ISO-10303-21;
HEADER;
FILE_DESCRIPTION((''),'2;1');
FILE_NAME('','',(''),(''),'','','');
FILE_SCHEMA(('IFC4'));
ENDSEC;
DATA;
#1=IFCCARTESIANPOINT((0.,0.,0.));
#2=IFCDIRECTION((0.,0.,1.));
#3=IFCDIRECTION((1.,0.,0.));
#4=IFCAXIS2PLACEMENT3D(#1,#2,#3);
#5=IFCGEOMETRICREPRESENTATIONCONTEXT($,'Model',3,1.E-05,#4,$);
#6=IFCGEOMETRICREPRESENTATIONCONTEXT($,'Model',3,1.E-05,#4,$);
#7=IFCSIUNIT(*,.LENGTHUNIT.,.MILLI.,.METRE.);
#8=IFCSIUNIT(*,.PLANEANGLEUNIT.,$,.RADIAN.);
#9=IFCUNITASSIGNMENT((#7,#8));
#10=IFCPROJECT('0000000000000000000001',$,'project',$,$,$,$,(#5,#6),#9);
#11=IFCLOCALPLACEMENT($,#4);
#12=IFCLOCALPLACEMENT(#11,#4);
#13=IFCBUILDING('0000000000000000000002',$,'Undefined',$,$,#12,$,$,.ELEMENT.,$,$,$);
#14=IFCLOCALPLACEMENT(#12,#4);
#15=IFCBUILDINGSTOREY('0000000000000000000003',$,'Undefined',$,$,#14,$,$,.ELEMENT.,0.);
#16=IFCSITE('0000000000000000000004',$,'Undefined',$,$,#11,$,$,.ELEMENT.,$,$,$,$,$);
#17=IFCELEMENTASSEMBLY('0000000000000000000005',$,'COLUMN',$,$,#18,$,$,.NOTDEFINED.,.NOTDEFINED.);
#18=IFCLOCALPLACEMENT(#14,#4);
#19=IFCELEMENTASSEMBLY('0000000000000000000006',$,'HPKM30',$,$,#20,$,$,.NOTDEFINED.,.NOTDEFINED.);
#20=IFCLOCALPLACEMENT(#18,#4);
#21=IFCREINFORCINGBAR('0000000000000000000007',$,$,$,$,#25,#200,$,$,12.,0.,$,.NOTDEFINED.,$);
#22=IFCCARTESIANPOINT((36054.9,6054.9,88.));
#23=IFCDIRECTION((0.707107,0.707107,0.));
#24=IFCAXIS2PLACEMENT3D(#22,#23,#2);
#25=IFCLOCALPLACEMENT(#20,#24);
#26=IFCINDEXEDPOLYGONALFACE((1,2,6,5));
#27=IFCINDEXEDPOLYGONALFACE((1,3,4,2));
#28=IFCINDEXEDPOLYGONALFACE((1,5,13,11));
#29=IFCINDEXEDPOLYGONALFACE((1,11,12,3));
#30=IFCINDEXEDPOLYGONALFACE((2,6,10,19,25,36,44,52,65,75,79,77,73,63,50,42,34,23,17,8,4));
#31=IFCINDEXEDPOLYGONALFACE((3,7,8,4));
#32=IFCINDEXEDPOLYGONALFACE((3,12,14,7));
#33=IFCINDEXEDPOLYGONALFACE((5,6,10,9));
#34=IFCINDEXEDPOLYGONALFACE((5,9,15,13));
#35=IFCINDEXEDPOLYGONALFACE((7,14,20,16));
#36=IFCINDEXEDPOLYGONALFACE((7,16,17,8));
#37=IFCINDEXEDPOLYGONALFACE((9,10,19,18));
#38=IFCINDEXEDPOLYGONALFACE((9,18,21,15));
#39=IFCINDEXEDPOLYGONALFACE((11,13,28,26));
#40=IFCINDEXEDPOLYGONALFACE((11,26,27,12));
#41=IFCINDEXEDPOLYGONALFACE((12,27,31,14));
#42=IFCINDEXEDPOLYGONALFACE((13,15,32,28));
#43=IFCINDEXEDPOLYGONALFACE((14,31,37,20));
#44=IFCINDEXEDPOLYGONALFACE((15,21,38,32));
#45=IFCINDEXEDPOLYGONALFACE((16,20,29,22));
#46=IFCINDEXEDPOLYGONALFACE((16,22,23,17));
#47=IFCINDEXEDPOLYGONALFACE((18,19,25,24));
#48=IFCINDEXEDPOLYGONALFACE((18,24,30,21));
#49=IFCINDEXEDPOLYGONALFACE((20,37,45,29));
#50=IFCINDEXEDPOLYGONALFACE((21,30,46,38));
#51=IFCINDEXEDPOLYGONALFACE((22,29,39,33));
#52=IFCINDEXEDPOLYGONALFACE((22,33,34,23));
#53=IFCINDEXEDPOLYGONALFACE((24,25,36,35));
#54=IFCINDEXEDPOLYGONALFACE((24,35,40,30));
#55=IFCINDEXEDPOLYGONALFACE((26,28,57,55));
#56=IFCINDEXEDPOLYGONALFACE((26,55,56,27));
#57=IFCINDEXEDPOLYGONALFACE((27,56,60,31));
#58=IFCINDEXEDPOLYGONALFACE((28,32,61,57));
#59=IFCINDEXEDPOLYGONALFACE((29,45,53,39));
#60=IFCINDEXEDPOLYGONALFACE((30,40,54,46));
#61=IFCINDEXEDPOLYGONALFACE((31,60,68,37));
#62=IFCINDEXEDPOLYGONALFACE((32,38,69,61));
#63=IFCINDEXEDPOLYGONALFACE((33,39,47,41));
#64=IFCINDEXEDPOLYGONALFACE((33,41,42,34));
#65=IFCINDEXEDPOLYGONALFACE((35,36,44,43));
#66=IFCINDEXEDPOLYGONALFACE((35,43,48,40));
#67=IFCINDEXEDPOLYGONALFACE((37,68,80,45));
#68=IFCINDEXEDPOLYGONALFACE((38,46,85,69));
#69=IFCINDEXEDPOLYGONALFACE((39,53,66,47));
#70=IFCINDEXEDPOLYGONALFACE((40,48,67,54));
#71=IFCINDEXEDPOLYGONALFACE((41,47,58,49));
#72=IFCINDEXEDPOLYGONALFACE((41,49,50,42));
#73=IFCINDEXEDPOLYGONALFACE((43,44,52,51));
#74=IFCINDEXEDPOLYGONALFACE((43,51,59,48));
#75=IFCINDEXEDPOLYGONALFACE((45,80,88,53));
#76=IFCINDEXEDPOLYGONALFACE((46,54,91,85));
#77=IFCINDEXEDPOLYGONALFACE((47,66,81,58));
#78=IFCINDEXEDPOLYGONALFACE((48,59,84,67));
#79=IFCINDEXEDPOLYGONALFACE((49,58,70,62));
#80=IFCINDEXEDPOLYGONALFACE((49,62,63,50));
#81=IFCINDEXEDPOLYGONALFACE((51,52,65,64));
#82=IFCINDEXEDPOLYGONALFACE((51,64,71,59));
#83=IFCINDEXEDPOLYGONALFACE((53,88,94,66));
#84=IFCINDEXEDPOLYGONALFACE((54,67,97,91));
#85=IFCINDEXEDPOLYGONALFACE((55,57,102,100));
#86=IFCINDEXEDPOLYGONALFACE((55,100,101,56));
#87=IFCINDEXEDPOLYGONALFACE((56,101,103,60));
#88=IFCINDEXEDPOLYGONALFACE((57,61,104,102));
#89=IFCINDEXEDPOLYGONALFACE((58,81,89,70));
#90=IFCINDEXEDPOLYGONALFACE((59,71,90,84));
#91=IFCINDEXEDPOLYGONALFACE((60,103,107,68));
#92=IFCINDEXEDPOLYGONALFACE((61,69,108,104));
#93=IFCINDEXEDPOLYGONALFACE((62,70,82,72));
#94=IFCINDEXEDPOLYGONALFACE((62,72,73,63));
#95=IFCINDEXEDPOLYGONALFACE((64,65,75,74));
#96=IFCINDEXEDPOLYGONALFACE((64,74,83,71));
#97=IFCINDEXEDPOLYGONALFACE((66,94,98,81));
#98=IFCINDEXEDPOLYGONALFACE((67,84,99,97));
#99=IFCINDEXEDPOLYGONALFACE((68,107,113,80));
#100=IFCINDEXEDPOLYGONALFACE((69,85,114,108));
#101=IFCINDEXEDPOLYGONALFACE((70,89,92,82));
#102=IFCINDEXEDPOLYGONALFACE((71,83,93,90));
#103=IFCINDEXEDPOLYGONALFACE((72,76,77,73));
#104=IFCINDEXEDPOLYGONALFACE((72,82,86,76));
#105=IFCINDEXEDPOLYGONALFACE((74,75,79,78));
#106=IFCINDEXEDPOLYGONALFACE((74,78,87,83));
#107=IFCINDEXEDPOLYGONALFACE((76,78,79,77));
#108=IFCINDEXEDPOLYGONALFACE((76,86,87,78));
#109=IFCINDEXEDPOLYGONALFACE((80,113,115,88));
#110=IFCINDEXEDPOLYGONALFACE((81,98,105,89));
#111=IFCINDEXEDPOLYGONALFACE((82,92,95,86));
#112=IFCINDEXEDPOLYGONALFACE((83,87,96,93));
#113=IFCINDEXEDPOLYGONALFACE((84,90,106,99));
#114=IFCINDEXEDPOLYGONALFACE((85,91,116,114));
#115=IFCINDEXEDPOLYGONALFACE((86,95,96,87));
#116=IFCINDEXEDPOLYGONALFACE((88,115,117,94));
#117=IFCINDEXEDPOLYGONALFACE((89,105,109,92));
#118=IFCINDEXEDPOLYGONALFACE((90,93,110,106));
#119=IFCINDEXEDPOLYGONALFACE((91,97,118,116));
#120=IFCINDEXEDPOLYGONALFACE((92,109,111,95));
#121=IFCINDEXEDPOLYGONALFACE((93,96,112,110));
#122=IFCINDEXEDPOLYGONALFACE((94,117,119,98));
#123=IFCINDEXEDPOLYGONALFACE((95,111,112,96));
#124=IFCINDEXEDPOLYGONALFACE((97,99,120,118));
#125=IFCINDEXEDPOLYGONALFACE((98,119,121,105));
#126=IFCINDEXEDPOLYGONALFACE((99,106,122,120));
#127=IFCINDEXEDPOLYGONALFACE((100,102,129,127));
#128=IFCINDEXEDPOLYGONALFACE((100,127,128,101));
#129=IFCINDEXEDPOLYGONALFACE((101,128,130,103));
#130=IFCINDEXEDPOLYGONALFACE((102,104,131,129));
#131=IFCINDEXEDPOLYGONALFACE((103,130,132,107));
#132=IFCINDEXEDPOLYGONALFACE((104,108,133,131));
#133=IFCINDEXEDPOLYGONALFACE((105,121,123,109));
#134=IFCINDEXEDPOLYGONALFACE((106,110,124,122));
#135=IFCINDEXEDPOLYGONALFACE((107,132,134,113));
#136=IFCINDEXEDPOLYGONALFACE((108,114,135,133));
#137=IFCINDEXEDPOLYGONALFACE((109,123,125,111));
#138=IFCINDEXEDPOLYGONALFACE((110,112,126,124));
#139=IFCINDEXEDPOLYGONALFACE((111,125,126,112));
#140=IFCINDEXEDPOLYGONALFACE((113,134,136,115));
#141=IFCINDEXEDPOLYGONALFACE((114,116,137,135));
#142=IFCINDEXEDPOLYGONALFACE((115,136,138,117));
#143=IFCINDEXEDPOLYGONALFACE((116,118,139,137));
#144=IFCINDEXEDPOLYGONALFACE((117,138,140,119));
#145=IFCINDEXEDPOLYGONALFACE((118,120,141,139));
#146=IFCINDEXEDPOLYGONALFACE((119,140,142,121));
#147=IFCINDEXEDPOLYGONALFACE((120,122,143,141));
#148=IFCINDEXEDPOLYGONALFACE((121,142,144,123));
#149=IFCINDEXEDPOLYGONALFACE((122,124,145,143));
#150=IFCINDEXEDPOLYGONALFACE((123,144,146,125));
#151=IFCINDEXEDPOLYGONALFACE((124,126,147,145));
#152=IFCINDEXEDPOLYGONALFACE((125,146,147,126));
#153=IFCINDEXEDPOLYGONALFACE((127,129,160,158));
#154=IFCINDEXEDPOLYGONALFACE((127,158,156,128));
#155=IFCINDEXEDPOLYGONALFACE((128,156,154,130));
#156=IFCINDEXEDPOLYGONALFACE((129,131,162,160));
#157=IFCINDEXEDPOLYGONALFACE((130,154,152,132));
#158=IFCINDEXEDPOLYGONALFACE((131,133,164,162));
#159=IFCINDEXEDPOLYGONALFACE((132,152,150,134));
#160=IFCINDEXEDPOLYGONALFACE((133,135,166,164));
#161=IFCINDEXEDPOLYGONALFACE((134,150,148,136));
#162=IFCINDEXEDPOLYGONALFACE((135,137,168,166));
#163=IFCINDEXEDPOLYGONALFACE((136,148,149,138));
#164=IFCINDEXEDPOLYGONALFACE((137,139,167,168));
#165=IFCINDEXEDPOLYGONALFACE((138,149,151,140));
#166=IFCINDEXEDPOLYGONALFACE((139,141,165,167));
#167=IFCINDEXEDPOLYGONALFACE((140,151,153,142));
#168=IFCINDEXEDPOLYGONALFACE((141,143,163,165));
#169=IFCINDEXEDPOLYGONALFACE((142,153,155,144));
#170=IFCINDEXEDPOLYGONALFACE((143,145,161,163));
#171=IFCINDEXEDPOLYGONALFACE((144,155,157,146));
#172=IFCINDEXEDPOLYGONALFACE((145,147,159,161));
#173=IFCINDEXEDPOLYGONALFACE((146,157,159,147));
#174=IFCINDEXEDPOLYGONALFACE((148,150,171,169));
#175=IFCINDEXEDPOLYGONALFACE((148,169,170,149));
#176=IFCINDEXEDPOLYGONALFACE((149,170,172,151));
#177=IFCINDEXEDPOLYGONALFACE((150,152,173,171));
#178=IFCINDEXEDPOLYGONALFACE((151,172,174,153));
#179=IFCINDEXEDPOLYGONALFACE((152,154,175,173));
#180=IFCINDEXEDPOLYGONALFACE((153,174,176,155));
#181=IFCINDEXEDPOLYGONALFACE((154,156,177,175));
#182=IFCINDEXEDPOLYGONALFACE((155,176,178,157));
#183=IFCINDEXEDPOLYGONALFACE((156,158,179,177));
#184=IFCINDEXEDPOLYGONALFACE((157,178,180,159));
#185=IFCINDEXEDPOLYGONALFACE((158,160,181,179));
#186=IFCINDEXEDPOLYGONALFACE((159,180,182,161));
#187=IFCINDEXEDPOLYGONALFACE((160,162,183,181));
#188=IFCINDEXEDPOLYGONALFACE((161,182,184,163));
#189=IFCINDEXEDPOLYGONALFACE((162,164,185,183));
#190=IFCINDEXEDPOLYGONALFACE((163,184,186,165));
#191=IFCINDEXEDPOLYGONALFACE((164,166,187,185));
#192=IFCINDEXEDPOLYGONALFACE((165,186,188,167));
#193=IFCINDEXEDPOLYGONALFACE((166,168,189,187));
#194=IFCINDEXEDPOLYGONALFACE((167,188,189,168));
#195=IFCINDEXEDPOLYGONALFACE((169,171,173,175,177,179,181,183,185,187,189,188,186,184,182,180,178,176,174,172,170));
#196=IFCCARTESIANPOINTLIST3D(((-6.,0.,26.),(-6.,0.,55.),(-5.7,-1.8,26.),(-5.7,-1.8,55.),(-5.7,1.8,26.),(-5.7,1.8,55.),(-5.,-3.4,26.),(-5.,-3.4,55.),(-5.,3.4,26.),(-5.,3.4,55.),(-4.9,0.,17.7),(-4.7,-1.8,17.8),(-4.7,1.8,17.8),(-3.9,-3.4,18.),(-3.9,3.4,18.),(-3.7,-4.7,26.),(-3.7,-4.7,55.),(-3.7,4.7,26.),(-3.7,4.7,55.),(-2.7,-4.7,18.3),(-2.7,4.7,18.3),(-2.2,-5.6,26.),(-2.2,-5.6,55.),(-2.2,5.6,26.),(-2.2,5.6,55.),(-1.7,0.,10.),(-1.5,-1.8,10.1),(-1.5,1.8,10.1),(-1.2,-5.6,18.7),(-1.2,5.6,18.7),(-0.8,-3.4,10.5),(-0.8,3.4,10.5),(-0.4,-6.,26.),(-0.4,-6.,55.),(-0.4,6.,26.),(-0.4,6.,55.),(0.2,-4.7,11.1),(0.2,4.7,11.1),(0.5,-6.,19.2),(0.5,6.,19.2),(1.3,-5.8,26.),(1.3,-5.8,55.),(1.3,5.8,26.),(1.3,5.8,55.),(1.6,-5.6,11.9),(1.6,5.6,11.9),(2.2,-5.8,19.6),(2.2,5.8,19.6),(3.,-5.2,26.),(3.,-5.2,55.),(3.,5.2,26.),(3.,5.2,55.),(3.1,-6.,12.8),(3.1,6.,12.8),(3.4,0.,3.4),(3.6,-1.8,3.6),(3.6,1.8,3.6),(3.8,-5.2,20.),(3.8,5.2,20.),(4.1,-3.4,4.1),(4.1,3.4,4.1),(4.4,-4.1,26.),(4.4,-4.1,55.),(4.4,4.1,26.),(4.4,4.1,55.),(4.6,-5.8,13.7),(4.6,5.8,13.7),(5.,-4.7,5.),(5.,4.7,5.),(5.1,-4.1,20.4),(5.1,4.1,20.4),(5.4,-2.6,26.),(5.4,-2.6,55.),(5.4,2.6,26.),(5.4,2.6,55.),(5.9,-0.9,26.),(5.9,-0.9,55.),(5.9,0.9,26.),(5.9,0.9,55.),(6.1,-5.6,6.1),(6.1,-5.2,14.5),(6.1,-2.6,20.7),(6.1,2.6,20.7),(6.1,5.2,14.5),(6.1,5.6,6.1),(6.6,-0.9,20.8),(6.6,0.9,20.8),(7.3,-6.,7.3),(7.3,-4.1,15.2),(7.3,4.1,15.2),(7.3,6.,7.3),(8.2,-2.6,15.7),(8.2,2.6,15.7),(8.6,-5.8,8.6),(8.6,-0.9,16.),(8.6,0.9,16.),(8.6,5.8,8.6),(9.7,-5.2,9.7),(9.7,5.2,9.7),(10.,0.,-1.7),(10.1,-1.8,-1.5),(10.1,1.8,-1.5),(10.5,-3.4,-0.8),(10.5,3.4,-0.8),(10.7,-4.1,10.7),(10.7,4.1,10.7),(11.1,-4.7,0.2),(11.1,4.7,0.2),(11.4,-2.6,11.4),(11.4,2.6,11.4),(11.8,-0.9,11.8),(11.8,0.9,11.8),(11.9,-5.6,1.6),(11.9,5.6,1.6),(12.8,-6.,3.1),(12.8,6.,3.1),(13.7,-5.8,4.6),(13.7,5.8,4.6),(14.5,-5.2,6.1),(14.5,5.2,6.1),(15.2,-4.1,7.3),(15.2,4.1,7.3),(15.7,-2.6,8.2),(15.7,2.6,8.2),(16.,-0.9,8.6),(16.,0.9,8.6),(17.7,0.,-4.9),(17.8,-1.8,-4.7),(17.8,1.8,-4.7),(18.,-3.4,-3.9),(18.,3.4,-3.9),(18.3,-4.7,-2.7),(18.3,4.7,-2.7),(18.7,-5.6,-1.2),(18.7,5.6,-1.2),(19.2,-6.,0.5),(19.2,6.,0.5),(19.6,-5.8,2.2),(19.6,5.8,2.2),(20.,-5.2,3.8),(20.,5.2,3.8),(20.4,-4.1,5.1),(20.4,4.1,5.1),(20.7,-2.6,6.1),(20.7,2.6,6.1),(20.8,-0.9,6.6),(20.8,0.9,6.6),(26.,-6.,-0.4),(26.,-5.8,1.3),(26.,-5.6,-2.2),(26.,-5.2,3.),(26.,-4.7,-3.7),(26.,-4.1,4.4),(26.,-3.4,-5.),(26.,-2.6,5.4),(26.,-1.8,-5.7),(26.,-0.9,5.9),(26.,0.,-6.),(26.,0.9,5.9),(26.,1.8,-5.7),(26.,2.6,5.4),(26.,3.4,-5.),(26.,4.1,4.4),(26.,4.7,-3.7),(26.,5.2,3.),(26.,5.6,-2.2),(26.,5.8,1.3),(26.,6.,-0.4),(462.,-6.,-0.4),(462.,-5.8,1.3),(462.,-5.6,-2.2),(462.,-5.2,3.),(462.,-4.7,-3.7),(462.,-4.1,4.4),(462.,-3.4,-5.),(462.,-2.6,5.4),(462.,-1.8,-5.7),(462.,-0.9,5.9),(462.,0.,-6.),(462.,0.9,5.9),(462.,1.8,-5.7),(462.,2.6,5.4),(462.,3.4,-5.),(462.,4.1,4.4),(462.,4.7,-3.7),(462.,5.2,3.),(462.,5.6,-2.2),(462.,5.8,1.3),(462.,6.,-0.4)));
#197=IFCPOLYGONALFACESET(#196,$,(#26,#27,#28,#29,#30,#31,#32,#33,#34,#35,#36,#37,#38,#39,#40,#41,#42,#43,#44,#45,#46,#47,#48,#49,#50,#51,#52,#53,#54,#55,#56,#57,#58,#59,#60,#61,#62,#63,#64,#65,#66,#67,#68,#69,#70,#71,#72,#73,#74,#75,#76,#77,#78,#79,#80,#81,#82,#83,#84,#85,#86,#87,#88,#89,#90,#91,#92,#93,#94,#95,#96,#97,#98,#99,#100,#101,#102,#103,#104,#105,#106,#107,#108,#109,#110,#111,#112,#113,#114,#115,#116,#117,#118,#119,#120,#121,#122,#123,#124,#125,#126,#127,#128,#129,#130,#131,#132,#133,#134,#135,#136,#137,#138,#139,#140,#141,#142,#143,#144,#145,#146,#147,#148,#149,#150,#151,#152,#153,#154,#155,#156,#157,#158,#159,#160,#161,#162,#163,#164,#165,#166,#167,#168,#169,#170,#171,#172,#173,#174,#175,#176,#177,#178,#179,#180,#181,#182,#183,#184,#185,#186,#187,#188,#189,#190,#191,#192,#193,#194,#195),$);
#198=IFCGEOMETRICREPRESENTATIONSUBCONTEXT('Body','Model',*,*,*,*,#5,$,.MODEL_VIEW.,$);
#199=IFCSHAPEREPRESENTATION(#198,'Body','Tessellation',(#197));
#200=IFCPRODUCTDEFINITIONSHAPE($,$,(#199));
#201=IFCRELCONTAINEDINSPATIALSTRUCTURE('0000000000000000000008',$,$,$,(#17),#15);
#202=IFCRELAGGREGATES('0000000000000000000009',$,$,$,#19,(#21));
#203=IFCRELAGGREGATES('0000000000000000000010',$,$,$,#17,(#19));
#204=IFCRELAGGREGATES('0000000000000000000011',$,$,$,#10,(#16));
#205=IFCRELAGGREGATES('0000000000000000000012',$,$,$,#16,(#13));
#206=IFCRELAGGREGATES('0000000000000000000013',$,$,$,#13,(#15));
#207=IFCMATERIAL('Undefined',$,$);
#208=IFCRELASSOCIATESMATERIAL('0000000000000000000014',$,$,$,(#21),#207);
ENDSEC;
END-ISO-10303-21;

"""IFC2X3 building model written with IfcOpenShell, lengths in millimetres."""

from ifc_helpers import new_model, entity, si_unit, frame, origin_with_axes, place, context, subcontext, project, spatial, source, transform, mapped, material, element, aggregate, save


model = new_model("IFC2X3")

# Units and contexts
model_context_1 = context("Model", 3, precision=1e-05, world=origin_with_axes())
model_context_2 = context("Model", 3, precision=1e-05, world=origin_with_axes())
body_context = subcontext(model_context_1, "Body", "Model", "MODEL_VIEW")
ifc_project = project(units=[si_unit("LENGTHUNIT", "METRE", prefix="MILLI"), si_unit("PLANEANGLEUNIT", "RADIAN")], contexts=[model_context_1, model_context_2])

# Site, building, storey
site_placement = place(None, origin_with_axes())
site = spatial("IfcSite", under=ifc_project, at=site_placement, Name="Undefined", CompositionType="ELEMENT")
building_placement = place(site_placement, origin_with_axes())
building = spatial("IfcBuilding", under=site, at=building_placement, Name="Undefined", CompositionType="ELEMENT")
storey_placement = place(building_placement, origin_with_axes())
storey = spatial("IfcBuildingStorey", under=building, at=storey_placement, Name="Undefined", CompositionType="ELEMENT", Elevation=0.0)

# Element assembly
assembly_1_placement = place(storey_placement, origin_with_axes())
assembly_1 = element("IfcElementAssembly", 1, at=assembly_1_placement, inside=storey, Name="COLUMN", AssemblyPlace="NOTDEFINED", PredefinedType="NOTDEFINED")

# Element assembly
assembly_2_placement = place(assembly_1_placement, origin_with_axes())
assembly_2 = element("IfcElementAssembly", 2, at=assembly_2_placement, Name="HPKM30", AssemblyPlace="NOTDEFINED", PredefinedType="NOTDEFINED")

# Shared definitions
ifc_material_1 = material(Name="Undefined")

# Reinforcing bar
shared_shape_1 = source(origin_with_axes(), body_context, "Body", "AdvancedSweptSolid", [
    entity("IfcSweptDiskSolid", entity("IfcCompositeCurve", [entity("IfcCompositeCurveSegment", "CONTINUOUS", True, entity("IfcTrimmedCurve", entity("IfcLine", entity("IfcCartesianPoint", [0.0, 0.0, 0.0]), entity("IfcVector", entity("IfcDirection", [0.0, 0.0, -1.0]), 1.0)), [entity("IfcParameterValue", 0.0)], [entity("IfcParameterValue", 29.0)], True, "PARAMETER")), entity("IfcCompositeCurveSegment", "CONTINUOUS", True, entity("IfcTrimmedCurve", entity("IfcCircle", entity("IfcAxis2Placement3D", entity("IfcCartesianPoint", [26.0, 0.0, -29.0]), entity("IfcDirection", [0.0, -1.0, 0.0]), entity("IfcDirection", [-1.0, 0.0, 0.0])), 26.0), [entity("IfcParameterValue", 0.0)], [entity("IfcParameterValue", 1.570796)], True, "PARAMETER")), entity("IfcCompositeCurveSegment", "DISCONTINUOUS", True, entity("IfcTrimmedCurve", entity("IfcLine", entity("IfcCartesianPoint", [26.0, 0.0, -55.0]), entity("IfcVector", entity("IfcDirection", [1.0, 0.0, 0.0]), 1.0)), [entity("IfcParameterValue", 0.0)], [entity("IfcParameterValue", 436.0)], True, "PARAMETER"))], False), 6.0, None, 0.0, 466.6),
])
reinforcing_bar_1_placement = place(assembly_2_placement, frame((36054.9, 6054.9, 88.0), z_axis=(0.707107, 0.707107, 0.0), x_axis=(0.0, 0.0, 1.0)))
reinforcing_bar_1 = element("IfcReinforcingBar", 3, at=reinforcing_bar_1_placement, material=ifc_material_1, BarRole="NOTDEFINED", CrossSectionArea=0.0, NominalDiameter=12.0, context=body_context, shape_type="MappedRepresentation", body=[
    mapped(shared_shape_1, transform((0.0, 0.0, 55.0))),
])
aggregate(assembly_2, [reinforcing_bar_1])
aggregate(assembly_1, [assembly_2])

save(model, "model.ifc")
